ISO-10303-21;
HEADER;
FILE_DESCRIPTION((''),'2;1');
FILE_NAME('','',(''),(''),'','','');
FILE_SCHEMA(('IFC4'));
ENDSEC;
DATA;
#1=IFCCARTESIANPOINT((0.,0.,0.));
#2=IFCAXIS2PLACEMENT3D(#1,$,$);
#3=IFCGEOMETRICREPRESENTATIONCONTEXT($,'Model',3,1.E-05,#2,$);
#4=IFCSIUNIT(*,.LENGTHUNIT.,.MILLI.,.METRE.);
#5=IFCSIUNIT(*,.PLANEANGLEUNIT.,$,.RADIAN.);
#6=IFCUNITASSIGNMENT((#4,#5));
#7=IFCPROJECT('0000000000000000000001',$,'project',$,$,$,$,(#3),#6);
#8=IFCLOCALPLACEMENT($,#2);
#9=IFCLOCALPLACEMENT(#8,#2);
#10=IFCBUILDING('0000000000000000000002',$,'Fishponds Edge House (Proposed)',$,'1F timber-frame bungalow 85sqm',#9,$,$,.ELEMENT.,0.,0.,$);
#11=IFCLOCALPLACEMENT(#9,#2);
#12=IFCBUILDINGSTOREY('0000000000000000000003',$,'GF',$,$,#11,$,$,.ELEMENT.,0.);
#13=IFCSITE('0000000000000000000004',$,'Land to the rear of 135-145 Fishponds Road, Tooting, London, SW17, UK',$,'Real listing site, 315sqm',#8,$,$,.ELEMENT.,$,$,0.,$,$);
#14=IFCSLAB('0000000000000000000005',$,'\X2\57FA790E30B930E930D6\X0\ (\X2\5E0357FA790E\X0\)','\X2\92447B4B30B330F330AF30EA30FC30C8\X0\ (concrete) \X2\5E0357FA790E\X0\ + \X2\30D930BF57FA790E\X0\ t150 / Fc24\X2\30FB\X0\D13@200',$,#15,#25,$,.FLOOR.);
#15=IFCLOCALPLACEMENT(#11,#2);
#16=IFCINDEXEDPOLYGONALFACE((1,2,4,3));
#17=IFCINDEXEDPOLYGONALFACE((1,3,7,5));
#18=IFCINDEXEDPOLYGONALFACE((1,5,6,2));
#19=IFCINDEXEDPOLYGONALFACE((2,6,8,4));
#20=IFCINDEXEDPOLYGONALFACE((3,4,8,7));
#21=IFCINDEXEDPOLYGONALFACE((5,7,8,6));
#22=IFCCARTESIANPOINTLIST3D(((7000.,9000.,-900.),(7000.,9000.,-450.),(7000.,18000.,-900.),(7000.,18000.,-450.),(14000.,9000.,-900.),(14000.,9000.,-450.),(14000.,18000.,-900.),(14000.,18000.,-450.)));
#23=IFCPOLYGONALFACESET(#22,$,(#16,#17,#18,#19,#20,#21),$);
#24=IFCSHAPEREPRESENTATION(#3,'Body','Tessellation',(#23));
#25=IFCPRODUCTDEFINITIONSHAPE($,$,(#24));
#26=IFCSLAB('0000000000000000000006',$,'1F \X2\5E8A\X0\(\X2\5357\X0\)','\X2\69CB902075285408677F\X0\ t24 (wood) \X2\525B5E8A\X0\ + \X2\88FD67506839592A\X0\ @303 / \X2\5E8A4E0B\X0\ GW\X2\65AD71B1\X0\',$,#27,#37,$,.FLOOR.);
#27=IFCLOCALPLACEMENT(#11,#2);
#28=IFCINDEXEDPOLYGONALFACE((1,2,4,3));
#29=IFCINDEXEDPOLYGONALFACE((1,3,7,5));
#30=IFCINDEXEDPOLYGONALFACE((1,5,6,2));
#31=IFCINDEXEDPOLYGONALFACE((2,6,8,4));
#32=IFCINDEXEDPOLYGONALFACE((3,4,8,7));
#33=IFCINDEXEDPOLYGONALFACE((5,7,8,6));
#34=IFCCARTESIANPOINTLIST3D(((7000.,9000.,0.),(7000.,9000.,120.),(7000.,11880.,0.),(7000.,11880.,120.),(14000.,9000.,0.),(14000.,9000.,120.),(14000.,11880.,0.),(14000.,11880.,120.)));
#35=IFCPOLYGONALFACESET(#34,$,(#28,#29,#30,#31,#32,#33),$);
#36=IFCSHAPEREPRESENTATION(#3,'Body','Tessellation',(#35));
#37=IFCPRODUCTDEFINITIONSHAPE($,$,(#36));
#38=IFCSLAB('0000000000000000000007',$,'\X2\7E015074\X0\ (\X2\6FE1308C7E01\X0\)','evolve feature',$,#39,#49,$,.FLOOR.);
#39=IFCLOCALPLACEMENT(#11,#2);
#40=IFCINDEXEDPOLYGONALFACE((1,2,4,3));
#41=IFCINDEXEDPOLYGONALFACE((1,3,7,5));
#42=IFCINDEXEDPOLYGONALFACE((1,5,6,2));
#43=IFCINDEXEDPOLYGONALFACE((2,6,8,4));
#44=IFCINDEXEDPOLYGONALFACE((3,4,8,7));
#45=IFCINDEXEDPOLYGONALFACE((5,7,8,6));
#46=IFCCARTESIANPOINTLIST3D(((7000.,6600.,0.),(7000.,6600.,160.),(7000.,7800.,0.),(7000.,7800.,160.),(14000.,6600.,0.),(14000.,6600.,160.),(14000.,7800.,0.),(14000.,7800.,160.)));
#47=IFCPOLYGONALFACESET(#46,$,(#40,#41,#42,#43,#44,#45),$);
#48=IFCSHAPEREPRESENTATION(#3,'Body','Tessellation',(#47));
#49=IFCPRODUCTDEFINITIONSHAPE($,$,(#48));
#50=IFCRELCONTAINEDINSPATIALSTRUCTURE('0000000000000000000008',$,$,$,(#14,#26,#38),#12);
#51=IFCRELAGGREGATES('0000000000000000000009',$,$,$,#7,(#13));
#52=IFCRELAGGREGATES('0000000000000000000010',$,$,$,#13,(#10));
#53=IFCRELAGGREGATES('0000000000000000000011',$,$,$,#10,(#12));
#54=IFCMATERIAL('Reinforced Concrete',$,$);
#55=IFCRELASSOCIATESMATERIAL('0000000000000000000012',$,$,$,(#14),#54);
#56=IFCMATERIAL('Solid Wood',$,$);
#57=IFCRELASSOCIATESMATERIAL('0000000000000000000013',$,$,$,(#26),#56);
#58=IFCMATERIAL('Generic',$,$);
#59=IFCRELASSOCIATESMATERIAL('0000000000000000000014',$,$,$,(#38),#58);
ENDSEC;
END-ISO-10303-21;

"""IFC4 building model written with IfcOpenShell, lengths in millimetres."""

from ifc_helpers import new_model, si_unit, frame, frame_2d, origin, place, context, project, spatial, rectangle, extrude, material, element, save


model = new_model("IFC4")

# Units and contexts
model_context = context("Model", 3, precision=1e-05, world=origin())
ifc_project = project(units=[si_unit("LENGTHUNIT", "METRE", prefix="MILLI"), si_unit("PLANEANGLEUNIT", "RADIAN")], contexts=[model_context])

# Site, building, storey
site_placement = place(None, origin())
site = spatial("IfcSite", under=ifc_project, at=site_placement, Name="Land to the rear of 135-145 Fishponds Road, Tooting, London, SW17, UK", ObjectType="Real listing site, 315sqm", CompositionType="ELEMENT", RefElevation=0.0)
building_placement = place(site_placement, origin())
building = spatial("IfcBuilding", under=site, at=building_placement, Name="Fishponds Edge House (Proposed)", ObjectType="1F timber-frame bungalow 85sqm", CompositionType="ELEMENT", ElevationOfRefHeight=0.0, ElevationOfTerrain=0.0)
storey_placement = place(building_placement, origin())
storey = spatial("IfcBuildingStorey", under=building, at=storey_placement, Name="GF", CompositionType="ELEMENT", Elevation=0.0)

# Slabs
ifc_material_1 = material(Name="Reinforced Concrete")
slab_1_placement = place(storey_placement, frame((3500.0, 4500.0, -450.0)))
element("IfcSlab", 1, at=slab_1_placement, inside=storey, material=ifc_material_1, Name="基礎スラブ (布基礎)", Description="鉄筋コンクリート (concrete) 布基礎 + ベタ基礎 t150 / Fc24・D13@200", PredefinedType="FLOOR", context=model_context, shape_type="SweptSolid", body=[
    extrude(rectangle(XDim=7000.0, YDim=9000.0, at=frame_2d((3500.0, 4500.0))), frame((3500.0, 4500.0, -450.0)), (0.0, 0.0, 1.0), 450.0),
])
ifc_material_2 = material(Name="Solid Wood")
slab_2_placement = place(storey_placement, frame((3500.0, 4500.0, 0.0)))
element("IfcSlab", 2, at=slab_2_placement, inside=storey, material=ifc_material_2, Name="1F 床(南)", Description="構造用合板 t24 (wood) 剛床 + 製材根太 @303 / 床下 GW断熱", PredefinedType="FLOOR", context=model_context, shape_type="SweptSolid", body=[
    extrude(rectangle(XDim=7000.0, YDim=2880.0, at=frame_2d((3500.0, 1440.0))), frame((3500.0, 4500.0, 0.0)), (0.0, 0.0, 1.0), 120.0),
])
ifc_material_3 = material(Name="Generic")
slab_3_placement = place(storey_placement, frame((3500.0, 3300.0, 0.0)))
element("IfcSlab", 3, at=slab_3_placement, inside=storey, material=ifc_material_3, Name="縁側 (濡れ縁)", Description="evolve feature", PredefinedType="FLOOR", context=model_context, shape_type="SweptSolid", body=[
    extrude(rectangle(XDim=7000.0, YDim=1200.0, at=frame_2d((3500.0, 600.0))), frame((3500.0, 3300.0, 0.0)), (0.0, 0.0, 1.0), 160.0),
])

save(model, "model.ifc")
